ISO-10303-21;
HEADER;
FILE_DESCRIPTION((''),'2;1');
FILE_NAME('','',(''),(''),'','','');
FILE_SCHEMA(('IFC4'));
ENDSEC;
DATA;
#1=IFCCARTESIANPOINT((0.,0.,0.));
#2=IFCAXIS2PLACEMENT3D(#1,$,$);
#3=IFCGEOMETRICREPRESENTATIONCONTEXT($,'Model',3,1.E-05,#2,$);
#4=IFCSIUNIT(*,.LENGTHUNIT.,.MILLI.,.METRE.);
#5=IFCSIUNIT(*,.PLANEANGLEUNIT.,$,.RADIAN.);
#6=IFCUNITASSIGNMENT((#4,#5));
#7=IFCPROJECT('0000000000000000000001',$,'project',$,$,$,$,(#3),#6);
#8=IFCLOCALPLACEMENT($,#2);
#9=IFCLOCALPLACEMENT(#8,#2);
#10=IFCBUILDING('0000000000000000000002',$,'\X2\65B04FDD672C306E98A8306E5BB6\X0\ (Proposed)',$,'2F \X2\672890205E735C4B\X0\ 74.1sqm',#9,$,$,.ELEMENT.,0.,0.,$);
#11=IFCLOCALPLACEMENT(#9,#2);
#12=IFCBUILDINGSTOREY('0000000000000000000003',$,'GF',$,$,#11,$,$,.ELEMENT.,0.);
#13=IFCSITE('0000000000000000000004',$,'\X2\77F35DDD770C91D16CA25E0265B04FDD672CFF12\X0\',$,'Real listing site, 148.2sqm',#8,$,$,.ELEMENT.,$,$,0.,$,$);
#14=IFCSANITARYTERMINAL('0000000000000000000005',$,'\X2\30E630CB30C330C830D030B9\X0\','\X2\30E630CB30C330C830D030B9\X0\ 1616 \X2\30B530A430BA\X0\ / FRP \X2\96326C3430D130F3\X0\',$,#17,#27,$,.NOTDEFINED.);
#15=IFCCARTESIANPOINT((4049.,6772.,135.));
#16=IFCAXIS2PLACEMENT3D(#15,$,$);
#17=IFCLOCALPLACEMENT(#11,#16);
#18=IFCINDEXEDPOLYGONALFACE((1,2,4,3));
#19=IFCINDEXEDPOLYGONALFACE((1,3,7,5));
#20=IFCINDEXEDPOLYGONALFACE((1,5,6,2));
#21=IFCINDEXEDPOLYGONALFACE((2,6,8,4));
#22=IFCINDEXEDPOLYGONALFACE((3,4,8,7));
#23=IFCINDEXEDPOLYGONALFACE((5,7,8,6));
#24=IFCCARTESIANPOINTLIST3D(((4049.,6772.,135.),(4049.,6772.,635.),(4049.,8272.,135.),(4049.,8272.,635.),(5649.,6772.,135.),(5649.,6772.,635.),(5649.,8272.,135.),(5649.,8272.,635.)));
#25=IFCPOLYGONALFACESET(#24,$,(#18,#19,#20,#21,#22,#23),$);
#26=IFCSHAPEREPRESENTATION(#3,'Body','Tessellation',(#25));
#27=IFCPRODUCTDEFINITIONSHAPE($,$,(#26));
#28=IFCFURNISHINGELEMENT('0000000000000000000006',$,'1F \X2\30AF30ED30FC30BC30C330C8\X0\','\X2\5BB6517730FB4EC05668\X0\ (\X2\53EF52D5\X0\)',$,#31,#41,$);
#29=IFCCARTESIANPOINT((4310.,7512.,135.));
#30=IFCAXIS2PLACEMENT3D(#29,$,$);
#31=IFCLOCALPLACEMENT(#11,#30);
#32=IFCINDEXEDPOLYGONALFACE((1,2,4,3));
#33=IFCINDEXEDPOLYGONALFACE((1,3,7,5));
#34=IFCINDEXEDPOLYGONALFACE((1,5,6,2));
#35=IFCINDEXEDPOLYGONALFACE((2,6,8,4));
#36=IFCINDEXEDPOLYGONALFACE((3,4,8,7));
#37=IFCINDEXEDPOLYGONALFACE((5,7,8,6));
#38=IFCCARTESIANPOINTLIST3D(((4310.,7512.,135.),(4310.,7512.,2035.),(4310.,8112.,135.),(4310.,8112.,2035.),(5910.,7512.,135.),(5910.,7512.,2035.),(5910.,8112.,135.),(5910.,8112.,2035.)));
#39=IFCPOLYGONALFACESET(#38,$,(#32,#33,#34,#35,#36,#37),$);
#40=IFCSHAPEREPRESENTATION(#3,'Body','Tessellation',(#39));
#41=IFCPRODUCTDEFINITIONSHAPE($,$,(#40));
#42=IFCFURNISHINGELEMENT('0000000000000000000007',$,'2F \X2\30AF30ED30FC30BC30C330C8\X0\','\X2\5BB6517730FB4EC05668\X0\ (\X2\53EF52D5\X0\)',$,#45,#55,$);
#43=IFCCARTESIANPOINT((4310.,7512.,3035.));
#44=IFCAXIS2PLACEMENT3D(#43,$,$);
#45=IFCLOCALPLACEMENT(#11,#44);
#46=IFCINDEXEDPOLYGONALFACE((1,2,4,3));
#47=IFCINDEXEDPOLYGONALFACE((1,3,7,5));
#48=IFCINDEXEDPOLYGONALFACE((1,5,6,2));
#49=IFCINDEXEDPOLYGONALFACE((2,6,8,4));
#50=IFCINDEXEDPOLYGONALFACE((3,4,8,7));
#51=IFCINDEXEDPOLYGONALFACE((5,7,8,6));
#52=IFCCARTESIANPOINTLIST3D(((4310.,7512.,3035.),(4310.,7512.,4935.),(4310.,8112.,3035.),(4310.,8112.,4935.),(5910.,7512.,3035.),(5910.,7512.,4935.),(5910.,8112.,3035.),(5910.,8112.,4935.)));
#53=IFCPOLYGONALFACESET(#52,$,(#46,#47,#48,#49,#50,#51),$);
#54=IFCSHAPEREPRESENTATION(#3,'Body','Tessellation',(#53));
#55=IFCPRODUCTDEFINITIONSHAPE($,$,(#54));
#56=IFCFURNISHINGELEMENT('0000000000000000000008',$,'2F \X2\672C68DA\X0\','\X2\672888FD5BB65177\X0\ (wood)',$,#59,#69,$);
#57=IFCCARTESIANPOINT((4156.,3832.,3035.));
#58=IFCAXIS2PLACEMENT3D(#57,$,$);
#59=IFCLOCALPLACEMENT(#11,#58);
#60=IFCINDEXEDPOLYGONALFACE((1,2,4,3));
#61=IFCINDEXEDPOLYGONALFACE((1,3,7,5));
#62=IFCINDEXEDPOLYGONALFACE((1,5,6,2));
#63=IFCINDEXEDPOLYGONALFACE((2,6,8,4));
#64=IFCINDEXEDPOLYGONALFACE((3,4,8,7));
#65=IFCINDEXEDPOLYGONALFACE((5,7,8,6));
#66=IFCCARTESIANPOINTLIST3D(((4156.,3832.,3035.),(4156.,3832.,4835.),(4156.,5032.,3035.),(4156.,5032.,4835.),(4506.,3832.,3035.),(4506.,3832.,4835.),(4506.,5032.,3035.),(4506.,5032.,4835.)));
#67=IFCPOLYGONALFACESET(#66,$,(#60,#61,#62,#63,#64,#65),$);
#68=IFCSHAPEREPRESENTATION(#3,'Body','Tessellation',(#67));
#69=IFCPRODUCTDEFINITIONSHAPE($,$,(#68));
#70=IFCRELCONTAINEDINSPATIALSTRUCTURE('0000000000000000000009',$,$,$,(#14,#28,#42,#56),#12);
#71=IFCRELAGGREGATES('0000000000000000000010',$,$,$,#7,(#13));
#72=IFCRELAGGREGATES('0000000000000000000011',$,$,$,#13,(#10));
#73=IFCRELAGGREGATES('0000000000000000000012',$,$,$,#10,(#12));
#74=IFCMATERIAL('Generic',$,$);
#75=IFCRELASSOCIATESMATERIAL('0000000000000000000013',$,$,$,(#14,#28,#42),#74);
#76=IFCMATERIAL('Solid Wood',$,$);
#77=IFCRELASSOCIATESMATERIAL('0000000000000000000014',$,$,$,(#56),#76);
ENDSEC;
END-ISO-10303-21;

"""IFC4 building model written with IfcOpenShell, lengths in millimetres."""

from ifc_helpers import new_model, si_unit, frame, frame_2d, origin, place, context, project, spatial, rectangle, extrude, material, element, save


model = new_model("IFC4")

# Units and contexts
model_context = context("Model", 3, precision=1e-05, world=origin())
ifc_project = project(units=[si_unit("LENGTHUNIT", "METRE", prefix="MILLI"), si_unit("PLANEANGLEUNIT", "RADIAN")], contexts=[model_context])

# Site, building, storey
site_placement = place(None, origin())
site = spatial("IfcSite", under=ifc_project, at=site_placement, Name="石川県金沢市新保本２", ObjectType="Real listing site, 148.2sqm", CompositionType="ELEMENT", RefElevation=0.0)
building_placement = place(site_placement, origin())
building = spatial("IfcBuilding", under=site, at=building_placement, Name="新保本の風の家 (Proposed)", ObjectType="2F 木造平屋 74.1sqm", CompositionType="ELEMENT", ElevationOfRefHeight=0.0, ElevationOfTerrain=0.0)
storey_placement = place(building_placement, origin())
storey = spatial("IfcBuildingStorey", under=building, at=storey_placement, Name="GF", CompositionType="ELEMENT", Elevation=0.0)

# Shared definitions
ifc_material_1 = material(Name="Solid Wood")

# Shared definitions
ifc_material_2 = material(Name="Generic")

# Sanitary terminal
sanitary_terminal_placement = place(storey_placement, frame((4049.0, 6772.0, 135.0)))
element("IfcSanitaryTerminal", 1, at=sanitary_terminal_placement, inside=storey, material=ifc_material_2, Name="ユニットバス", Description="ユニットバス 1616 サイズ / FRP 防水パン", PredefinedType="NOTDEFINED", context=model_context, shape_type="SweptSolid", body=[
    extrude(rectangle(XDim=1600.0, YDim=1500.0, at=frame_2d((800.0, 750.0))), frame((4049.0, 6772.0, 135.0)), (0.0, 0.0, 1.0), 500.0),
])

# Furnishing elements
furnishing_1_placement = place(storey_placement, frame((4310.0, 7512.0, 135.0)))
element("IfcFurnishingElement", 2, at=furnishing_1_placement, inside=storey, material=ifc_material_2, Name="1F クローゼット", Description="家具・什器 (可動)", context=model_context, shape_type="SweptSolid", body=[
    extrude(rectangle(XDim=1600.0, YDim=600.0, at=frame_2d((800.0, 300.0))), frame((4310.0, 7512.0, 135.0)), (0.0, 0.0, 1.0), 1900.0),
])
furnishing_2_placement = place(storey_placement, frame((4310.0, 7512.0, 3035.0)))
element("IfcFurnishingElement", 3, at=furnishing_2_placement, inside=storey, material=ifc_material_2, Name="2F クローゼット", Description="家具・什器 (可動)", context=model_context, shape_type="SweptSolid", body=[
    extrude(rectangle(XDim=1600.0, YDim=600.0, at=frame_2d((800.0, 300.0))), frame((4310.0, 7512.0, 3035.0)), (0.0, 0.0, 1.0), 1900.0),
])
furnishing_3_placement = place(storey_placement, frame((4156.0, 3832.0, 3035.0)))
element("IfcFurnishingElement", 4, at=furnishing_3_placement, inside=storey, material=ifc_material_1, Name="2F 本棚", Description="木製家具 (wood)", context=model_context, shape_type="SweptSolid", body=[
    extrude(rectangle(XDim=350.0, YDim=1200.0, at=frame_2d((175.0, 600.0))), frame((4156.0, 3832.0, 3035.0)), (0.0, 0.0, 1.0), 1800.0),
])

save(model, "model.ifc")
